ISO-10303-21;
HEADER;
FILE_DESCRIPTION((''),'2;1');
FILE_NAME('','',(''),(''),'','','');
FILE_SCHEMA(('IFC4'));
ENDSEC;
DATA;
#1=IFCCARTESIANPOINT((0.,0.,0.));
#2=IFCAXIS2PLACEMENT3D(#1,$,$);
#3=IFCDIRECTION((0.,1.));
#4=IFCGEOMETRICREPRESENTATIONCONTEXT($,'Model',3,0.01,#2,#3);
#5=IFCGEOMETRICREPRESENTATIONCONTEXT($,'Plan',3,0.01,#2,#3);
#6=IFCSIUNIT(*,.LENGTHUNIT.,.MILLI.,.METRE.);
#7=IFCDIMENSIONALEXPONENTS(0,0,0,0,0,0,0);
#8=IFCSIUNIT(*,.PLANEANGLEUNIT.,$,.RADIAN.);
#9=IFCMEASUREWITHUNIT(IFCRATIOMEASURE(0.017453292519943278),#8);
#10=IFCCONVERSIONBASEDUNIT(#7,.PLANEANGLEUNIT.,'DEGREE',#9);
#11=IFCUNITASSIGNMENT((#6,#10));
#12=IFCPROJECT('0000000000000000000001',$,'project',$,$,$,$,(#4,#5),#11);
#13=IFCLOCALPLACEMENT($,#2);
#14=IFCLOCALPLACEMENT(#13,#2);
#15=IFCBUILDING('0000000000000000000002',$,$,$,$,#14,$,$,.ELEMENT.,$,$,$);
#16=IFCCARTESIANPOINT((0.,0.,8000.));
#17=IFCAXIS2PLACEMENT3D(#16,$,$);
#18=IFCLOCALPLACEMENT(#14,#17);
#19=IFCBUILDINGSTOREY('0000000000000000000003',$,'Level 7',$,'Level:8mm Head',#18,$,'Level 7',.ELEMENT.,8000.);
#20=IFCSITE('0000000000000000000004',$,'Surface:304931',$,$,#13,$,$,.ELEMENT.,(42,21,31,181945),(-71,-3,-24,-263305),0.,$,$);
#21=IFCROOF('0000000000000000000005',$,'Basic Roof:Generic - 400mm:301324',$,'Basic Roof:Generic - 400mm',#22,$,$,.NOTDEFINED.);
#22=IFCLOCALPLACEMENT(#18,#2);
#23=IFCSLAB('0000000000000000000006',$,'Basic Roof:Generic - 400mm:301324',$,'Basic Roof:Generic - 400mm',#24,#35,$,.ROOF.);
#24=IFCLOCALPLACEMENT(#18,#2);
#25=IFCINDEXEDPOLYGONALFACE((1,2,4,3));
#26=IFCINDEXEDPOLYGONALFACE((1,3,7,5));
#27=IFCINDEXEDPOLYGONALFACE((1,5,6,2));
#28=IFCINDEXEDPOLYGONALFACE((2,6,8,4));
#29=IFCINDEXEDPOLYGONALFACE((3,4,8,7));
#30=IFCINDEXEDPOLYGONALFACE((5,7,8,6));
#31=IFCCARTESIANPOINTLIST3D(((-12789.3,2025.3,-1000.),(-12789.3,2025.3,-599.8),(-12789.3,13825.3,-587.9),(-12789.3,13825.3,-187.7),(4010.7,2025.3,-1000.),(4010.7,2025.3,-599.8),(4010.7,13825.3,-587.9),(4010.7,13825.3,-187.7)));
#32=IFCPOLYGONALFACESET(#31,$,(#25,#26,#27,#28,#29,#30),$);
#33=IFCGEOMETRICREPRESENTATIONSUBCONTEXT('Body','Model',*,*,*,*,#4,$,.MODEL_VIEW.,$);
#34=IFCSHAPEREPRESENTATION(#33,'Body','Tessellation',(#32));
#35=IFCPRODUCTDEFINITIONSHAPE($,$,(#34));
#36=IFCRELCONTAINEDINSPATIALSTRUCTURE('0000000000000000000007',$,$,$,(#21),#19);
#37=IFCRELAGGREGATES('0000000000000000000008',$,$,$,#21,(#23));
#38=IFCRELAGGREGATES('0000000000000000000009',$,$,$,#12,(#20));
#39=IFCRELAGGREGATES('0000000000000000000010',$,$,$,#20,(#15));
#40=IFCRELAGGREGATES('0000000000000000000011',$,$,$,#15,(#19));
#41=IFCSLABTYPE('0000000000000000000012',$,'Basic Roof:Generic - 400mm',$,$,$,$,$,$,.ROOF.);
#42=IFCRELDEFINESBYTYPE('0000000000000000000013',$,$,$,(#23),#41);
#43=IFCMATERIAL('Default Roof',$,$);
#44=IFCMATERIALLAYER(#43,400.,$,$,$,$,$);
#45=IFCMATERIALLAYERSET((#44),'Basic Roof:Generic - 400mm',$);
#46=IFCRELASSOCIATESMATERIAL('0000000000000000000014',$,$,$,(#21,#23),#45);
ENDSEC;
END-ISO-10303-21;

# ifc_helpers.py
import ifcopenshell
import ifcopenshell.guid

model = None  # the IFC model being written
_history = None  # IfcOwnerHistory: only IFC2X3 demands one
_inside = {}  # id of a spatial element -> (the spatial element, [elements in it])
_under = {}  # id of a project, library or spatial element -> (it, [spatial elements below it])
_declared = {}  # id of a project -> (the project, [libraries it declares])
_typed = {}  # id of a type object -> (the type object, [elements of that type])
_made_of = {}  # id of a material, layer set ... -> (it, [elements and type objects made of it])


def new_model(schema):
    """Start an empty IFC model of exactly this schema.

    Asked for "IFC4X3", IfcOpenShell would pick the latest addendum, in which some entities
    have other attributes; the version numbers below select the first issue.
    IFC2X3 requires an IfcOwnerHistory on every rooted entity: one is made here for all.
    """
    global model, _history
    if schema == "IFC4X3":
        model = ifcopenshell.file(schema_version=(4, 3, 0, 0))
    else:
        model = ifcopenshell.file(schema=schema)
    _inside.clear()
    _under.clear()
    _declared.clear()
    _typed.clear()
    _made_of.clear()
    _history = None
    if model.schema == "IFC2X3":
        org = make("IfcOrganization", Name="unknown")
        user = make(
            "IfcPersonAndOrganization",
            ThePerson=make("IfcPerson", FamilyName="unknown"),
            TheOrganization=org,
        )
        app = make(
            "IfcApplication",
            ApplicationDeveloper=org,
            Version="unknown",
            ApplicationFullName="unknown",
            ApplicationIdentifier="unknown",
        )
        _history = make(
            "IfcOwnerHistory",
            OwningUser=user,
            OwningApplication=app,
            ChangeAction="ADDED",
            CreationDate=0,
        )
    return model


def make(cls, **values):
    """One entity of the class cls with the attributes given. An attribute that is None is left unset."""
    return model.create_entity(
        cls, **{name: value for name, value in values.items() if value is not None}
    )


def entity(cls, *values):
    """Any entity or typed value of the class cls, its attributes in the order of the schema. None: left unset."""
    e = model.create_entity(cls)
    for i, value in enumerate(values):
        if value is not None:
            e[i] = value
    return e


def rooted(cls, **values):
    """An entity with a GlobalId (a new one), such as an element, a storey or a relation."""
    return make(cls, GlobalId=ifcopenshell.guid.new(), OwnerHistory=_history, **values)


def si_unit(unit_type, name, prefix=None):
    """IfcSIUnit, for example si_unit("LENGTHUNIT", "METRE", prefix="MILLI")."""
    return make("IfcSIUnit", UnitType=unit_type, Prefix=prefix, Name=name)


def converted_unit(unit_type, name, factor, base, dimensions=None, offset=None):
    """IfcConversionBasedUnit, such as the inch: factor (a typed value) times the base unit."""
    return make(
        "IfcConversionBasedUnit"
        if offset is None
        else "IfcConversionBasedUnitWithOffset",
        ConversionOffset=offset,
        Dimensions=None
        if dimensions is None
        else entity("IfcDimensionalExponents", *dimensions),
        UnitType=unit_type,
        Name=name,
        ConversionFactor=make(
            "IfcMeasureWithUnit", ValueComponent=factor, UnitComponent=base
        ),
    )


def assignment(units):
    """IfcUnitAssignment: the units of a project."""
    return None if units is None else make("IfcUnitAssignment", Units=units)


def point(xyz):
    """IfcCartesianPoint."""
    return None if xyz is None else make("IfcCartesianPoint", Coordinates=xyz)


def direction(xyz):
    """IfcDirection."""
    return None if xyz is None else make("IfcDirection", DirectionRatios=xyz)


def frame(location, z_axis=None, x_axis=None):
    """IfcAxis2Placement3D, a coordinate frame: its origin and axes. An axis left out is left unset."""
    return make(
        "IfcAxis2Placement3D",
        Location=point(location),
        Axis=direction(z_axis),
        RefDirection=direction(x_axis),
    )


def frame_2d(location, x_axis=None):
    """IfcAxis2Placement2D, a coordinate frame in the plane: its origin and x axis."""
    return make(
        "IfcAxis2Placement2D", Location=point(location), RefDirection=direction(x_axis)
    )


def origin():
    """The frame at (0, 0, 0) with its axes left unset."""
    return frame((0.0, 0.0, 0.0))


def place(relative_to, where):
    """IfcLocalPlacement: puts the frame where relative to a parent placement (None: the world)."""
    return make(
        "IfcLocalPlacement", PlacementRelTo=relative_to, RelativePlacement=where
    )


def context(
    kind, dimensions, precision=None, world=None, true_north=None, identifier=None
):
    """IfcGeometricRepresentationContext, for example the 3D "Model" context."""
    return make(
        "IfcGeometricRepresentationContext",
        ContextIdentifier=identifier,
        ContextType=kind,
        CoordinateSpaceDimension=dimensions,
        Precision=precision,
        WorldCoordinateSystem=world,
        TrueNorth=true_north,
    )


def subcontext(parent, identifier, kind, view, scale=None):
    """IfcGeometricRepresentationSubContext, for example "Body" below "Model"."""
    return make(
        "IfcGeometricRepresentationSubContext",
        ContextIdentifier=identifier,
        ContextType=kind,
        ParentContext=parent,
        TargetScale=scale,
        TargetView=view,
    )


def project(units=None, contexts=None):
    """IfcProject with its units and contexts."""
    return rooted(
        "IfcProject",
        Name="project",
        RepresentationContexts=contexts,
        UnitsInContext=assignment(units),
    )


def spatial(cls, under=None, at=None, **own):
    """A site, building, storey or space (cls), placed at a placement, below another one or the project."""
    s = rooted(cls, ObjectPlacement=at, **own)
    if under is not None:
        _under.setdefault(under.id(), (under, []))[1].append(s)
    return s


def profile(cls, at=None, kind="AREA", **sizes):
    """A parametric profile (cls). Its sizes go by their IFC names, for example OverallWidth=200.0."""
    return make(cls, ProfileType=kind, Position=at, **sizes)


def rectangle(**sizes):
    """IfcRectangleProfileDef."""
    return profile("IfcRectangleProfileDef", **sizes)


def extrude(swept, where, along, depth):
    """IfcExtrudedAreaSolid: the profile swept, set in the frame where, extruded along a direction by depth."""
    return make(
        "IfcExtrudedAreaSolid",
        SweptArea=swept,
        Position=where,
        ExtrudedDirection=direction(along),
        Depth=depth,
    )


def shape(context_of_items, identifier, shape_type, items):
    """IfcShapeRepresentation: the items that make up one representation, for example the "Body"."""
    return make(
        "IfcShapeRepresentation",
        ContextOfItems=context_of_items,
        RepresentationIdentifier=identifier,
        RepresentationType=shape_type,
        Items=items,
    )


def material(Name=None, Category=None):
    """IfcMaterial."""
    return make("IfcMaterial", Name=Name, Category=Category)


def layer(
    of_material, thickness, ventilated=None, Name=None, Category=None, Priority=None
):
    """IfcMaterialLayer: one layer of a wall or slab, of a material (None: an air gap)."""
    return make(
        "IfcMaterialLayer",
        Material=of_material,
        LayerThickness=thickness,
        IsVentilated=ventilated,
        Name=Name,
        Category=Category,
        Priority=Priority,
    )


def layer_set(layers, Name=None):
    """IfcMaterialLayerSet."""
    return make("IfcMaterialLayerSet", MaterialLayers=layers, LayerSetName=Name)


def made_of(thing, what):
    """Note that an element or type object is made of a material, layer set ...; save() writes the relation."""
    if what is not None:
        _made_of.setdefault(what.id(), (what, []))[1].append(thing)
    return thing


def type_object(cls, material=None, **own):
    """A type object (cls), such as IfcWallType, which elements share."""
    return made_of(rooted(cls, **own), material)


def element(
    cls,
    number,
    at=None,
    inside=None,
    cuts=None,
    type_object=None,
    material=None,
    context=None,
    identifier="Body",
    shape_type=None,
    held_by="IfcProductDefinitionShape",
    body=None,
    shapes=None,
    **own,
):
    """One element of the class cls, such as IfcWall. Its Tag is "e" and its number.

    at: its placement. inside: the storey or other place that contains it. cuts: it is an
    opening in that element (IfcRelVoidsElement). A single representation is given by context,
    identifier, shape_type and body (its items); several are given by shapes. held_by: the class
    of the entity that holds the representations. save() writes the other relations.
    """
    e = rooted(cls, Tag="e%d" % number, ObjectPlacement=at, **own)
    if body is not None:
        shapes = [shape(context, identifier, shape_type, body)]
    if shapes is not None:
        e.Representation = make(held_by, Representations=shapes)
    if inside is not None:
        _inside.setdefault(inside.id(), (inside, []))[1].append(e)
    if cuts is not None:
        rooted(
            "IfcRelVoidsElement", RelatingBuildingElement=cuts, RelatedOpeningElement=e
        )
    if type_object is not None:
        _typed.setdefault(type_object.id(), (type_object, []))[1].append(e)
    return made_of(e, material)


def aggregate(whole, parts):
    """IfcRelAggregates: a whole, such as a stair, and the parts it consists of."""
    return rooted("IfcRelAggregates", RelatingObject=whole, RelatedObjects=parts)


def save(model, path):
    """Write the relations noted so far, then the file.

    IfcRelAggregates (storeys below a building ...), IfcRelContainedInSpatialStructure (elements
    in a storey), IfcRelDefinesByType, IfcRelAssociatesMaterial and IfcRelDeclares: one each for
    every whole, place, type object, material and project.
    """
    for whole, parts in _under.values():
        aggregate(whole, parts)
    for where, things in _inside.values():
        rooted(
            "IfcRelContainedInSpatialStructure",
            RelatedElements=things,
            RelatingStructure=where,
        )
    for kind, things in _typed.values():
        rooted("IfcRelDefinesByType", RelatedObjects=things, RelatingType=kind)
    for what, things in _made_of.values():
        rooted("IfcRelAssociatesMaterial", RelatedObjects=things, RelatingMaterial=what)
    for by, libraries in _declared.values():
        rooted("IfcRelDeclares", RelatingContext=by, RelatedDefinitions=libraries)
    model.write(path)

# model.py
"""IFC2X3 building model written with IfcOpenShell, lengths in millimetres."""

from ifc_helpers import new_model, entity, si_unit, converted_unit, direction, frame, frame_2d, origin, place, context, subcontext, project, spatial, rectangle, extrude, material, layer, layer_set, type_object, element, aggregate, save


model = new_model("IFC2X3")

# Units and contexts
model_context = context("Model", 3, precision=0.01, world=origin(), true_north=direction((0.0, 1.0)))
plan_context = context("Plan", 3, precision=0.01, world=origin(), true_north=direction((0.0, 1.0)))
body_context = subcontext(model_context, "Body", "Model", "MODEL_VIEW")
ifc_project = project(units=[si_unit("LENGTHUNIT", "METRE", prefix="MILLI"), converted_unit("PLANEANGLEUNIT", "DEGREE", entity("IfcRatioMeasure", 0.017453292519943278), si_unit("PLANEANGLEUNIT", "RADIAN"), dimensions=[0, 0, 0, 0, 0, 0, 0])], contexts=[model_context, plan_context])

# Site, building, storey
site_placement = place(None, origin())
site = spatial("IfcSite", under=ifc_project, at=site_placement, Name="Surface:304931", CompositionType="ELEMENT", RefLatitude=(42, 21, 31, 181945), RefLongitude=(-71, -3, -24, -263305), RefElevation=0.0)
building_placement = place(site_placement, origin())
building = spatial("IfcBuilding", under=site, at=building_placement, CompositionType="ELEMENT")
storey_placement = place(building_placement, frame((0.0, 0.0, 8000.0)))
storey = spatial("IfcBuildingStorey", under=building, at=storey_placement, Name="Level 7", ObjectType="Level:8mm Head", LongName="Level 7", CompositionType="ELEMENT", Elevation=8000.0)

# Roof, slab
ifc_material = material(Name="Default Roof")
ifc_layer = layer(ifc_material, 400.0)
ifc_layer_set = layer_set([ifc_layer], Name="Basic Roof:Generic - 400mm")
roof_placement = place(storey_placement, frame((-12789.3, 2025.3, -1000.0)))
roof = element("IfcRoof", 1, at=roof_placement, inside=storey, material=ifc_layer_set, Name="Basic Roof:Generic - 400mm:301324", ObjectType="Basic Roof:Generic - 400mm", ShapeType="NOTDEFINED")
slab_type = type_object("IfcSlabType", Name="Basic Roof:Generic - 400mm", PredefinedType="ROOF")
slab_placement = place(roof_placement, origin())
slab = element("IfcSlab", 2, at=slab_placement, type_object=slab_type, material=ifc_layer_set, Name="Basic Roof:Generic - 400mm:301324", ObjectType="Basic Roof:Generic - 400mm", PredefinedType="ROOF", context=body_context, shape_type="SweptSolid", body=[
    extrude(rectangle(XDim=11807.2, YDim=16800.0, at=frame_2d((0.0, 0.0), x_axis=(0.0, -1.0))), frame((8400.0, 5900.0, 206.0), z_axis=(0.0, -0.034899, 0.999391), x_axis=(1.0, 0.0, 0.0)), (0.0, 0.034899, 0.999391), 400.2),
])
aggregate(roof, [slab])

save(model, "model.ifc")
